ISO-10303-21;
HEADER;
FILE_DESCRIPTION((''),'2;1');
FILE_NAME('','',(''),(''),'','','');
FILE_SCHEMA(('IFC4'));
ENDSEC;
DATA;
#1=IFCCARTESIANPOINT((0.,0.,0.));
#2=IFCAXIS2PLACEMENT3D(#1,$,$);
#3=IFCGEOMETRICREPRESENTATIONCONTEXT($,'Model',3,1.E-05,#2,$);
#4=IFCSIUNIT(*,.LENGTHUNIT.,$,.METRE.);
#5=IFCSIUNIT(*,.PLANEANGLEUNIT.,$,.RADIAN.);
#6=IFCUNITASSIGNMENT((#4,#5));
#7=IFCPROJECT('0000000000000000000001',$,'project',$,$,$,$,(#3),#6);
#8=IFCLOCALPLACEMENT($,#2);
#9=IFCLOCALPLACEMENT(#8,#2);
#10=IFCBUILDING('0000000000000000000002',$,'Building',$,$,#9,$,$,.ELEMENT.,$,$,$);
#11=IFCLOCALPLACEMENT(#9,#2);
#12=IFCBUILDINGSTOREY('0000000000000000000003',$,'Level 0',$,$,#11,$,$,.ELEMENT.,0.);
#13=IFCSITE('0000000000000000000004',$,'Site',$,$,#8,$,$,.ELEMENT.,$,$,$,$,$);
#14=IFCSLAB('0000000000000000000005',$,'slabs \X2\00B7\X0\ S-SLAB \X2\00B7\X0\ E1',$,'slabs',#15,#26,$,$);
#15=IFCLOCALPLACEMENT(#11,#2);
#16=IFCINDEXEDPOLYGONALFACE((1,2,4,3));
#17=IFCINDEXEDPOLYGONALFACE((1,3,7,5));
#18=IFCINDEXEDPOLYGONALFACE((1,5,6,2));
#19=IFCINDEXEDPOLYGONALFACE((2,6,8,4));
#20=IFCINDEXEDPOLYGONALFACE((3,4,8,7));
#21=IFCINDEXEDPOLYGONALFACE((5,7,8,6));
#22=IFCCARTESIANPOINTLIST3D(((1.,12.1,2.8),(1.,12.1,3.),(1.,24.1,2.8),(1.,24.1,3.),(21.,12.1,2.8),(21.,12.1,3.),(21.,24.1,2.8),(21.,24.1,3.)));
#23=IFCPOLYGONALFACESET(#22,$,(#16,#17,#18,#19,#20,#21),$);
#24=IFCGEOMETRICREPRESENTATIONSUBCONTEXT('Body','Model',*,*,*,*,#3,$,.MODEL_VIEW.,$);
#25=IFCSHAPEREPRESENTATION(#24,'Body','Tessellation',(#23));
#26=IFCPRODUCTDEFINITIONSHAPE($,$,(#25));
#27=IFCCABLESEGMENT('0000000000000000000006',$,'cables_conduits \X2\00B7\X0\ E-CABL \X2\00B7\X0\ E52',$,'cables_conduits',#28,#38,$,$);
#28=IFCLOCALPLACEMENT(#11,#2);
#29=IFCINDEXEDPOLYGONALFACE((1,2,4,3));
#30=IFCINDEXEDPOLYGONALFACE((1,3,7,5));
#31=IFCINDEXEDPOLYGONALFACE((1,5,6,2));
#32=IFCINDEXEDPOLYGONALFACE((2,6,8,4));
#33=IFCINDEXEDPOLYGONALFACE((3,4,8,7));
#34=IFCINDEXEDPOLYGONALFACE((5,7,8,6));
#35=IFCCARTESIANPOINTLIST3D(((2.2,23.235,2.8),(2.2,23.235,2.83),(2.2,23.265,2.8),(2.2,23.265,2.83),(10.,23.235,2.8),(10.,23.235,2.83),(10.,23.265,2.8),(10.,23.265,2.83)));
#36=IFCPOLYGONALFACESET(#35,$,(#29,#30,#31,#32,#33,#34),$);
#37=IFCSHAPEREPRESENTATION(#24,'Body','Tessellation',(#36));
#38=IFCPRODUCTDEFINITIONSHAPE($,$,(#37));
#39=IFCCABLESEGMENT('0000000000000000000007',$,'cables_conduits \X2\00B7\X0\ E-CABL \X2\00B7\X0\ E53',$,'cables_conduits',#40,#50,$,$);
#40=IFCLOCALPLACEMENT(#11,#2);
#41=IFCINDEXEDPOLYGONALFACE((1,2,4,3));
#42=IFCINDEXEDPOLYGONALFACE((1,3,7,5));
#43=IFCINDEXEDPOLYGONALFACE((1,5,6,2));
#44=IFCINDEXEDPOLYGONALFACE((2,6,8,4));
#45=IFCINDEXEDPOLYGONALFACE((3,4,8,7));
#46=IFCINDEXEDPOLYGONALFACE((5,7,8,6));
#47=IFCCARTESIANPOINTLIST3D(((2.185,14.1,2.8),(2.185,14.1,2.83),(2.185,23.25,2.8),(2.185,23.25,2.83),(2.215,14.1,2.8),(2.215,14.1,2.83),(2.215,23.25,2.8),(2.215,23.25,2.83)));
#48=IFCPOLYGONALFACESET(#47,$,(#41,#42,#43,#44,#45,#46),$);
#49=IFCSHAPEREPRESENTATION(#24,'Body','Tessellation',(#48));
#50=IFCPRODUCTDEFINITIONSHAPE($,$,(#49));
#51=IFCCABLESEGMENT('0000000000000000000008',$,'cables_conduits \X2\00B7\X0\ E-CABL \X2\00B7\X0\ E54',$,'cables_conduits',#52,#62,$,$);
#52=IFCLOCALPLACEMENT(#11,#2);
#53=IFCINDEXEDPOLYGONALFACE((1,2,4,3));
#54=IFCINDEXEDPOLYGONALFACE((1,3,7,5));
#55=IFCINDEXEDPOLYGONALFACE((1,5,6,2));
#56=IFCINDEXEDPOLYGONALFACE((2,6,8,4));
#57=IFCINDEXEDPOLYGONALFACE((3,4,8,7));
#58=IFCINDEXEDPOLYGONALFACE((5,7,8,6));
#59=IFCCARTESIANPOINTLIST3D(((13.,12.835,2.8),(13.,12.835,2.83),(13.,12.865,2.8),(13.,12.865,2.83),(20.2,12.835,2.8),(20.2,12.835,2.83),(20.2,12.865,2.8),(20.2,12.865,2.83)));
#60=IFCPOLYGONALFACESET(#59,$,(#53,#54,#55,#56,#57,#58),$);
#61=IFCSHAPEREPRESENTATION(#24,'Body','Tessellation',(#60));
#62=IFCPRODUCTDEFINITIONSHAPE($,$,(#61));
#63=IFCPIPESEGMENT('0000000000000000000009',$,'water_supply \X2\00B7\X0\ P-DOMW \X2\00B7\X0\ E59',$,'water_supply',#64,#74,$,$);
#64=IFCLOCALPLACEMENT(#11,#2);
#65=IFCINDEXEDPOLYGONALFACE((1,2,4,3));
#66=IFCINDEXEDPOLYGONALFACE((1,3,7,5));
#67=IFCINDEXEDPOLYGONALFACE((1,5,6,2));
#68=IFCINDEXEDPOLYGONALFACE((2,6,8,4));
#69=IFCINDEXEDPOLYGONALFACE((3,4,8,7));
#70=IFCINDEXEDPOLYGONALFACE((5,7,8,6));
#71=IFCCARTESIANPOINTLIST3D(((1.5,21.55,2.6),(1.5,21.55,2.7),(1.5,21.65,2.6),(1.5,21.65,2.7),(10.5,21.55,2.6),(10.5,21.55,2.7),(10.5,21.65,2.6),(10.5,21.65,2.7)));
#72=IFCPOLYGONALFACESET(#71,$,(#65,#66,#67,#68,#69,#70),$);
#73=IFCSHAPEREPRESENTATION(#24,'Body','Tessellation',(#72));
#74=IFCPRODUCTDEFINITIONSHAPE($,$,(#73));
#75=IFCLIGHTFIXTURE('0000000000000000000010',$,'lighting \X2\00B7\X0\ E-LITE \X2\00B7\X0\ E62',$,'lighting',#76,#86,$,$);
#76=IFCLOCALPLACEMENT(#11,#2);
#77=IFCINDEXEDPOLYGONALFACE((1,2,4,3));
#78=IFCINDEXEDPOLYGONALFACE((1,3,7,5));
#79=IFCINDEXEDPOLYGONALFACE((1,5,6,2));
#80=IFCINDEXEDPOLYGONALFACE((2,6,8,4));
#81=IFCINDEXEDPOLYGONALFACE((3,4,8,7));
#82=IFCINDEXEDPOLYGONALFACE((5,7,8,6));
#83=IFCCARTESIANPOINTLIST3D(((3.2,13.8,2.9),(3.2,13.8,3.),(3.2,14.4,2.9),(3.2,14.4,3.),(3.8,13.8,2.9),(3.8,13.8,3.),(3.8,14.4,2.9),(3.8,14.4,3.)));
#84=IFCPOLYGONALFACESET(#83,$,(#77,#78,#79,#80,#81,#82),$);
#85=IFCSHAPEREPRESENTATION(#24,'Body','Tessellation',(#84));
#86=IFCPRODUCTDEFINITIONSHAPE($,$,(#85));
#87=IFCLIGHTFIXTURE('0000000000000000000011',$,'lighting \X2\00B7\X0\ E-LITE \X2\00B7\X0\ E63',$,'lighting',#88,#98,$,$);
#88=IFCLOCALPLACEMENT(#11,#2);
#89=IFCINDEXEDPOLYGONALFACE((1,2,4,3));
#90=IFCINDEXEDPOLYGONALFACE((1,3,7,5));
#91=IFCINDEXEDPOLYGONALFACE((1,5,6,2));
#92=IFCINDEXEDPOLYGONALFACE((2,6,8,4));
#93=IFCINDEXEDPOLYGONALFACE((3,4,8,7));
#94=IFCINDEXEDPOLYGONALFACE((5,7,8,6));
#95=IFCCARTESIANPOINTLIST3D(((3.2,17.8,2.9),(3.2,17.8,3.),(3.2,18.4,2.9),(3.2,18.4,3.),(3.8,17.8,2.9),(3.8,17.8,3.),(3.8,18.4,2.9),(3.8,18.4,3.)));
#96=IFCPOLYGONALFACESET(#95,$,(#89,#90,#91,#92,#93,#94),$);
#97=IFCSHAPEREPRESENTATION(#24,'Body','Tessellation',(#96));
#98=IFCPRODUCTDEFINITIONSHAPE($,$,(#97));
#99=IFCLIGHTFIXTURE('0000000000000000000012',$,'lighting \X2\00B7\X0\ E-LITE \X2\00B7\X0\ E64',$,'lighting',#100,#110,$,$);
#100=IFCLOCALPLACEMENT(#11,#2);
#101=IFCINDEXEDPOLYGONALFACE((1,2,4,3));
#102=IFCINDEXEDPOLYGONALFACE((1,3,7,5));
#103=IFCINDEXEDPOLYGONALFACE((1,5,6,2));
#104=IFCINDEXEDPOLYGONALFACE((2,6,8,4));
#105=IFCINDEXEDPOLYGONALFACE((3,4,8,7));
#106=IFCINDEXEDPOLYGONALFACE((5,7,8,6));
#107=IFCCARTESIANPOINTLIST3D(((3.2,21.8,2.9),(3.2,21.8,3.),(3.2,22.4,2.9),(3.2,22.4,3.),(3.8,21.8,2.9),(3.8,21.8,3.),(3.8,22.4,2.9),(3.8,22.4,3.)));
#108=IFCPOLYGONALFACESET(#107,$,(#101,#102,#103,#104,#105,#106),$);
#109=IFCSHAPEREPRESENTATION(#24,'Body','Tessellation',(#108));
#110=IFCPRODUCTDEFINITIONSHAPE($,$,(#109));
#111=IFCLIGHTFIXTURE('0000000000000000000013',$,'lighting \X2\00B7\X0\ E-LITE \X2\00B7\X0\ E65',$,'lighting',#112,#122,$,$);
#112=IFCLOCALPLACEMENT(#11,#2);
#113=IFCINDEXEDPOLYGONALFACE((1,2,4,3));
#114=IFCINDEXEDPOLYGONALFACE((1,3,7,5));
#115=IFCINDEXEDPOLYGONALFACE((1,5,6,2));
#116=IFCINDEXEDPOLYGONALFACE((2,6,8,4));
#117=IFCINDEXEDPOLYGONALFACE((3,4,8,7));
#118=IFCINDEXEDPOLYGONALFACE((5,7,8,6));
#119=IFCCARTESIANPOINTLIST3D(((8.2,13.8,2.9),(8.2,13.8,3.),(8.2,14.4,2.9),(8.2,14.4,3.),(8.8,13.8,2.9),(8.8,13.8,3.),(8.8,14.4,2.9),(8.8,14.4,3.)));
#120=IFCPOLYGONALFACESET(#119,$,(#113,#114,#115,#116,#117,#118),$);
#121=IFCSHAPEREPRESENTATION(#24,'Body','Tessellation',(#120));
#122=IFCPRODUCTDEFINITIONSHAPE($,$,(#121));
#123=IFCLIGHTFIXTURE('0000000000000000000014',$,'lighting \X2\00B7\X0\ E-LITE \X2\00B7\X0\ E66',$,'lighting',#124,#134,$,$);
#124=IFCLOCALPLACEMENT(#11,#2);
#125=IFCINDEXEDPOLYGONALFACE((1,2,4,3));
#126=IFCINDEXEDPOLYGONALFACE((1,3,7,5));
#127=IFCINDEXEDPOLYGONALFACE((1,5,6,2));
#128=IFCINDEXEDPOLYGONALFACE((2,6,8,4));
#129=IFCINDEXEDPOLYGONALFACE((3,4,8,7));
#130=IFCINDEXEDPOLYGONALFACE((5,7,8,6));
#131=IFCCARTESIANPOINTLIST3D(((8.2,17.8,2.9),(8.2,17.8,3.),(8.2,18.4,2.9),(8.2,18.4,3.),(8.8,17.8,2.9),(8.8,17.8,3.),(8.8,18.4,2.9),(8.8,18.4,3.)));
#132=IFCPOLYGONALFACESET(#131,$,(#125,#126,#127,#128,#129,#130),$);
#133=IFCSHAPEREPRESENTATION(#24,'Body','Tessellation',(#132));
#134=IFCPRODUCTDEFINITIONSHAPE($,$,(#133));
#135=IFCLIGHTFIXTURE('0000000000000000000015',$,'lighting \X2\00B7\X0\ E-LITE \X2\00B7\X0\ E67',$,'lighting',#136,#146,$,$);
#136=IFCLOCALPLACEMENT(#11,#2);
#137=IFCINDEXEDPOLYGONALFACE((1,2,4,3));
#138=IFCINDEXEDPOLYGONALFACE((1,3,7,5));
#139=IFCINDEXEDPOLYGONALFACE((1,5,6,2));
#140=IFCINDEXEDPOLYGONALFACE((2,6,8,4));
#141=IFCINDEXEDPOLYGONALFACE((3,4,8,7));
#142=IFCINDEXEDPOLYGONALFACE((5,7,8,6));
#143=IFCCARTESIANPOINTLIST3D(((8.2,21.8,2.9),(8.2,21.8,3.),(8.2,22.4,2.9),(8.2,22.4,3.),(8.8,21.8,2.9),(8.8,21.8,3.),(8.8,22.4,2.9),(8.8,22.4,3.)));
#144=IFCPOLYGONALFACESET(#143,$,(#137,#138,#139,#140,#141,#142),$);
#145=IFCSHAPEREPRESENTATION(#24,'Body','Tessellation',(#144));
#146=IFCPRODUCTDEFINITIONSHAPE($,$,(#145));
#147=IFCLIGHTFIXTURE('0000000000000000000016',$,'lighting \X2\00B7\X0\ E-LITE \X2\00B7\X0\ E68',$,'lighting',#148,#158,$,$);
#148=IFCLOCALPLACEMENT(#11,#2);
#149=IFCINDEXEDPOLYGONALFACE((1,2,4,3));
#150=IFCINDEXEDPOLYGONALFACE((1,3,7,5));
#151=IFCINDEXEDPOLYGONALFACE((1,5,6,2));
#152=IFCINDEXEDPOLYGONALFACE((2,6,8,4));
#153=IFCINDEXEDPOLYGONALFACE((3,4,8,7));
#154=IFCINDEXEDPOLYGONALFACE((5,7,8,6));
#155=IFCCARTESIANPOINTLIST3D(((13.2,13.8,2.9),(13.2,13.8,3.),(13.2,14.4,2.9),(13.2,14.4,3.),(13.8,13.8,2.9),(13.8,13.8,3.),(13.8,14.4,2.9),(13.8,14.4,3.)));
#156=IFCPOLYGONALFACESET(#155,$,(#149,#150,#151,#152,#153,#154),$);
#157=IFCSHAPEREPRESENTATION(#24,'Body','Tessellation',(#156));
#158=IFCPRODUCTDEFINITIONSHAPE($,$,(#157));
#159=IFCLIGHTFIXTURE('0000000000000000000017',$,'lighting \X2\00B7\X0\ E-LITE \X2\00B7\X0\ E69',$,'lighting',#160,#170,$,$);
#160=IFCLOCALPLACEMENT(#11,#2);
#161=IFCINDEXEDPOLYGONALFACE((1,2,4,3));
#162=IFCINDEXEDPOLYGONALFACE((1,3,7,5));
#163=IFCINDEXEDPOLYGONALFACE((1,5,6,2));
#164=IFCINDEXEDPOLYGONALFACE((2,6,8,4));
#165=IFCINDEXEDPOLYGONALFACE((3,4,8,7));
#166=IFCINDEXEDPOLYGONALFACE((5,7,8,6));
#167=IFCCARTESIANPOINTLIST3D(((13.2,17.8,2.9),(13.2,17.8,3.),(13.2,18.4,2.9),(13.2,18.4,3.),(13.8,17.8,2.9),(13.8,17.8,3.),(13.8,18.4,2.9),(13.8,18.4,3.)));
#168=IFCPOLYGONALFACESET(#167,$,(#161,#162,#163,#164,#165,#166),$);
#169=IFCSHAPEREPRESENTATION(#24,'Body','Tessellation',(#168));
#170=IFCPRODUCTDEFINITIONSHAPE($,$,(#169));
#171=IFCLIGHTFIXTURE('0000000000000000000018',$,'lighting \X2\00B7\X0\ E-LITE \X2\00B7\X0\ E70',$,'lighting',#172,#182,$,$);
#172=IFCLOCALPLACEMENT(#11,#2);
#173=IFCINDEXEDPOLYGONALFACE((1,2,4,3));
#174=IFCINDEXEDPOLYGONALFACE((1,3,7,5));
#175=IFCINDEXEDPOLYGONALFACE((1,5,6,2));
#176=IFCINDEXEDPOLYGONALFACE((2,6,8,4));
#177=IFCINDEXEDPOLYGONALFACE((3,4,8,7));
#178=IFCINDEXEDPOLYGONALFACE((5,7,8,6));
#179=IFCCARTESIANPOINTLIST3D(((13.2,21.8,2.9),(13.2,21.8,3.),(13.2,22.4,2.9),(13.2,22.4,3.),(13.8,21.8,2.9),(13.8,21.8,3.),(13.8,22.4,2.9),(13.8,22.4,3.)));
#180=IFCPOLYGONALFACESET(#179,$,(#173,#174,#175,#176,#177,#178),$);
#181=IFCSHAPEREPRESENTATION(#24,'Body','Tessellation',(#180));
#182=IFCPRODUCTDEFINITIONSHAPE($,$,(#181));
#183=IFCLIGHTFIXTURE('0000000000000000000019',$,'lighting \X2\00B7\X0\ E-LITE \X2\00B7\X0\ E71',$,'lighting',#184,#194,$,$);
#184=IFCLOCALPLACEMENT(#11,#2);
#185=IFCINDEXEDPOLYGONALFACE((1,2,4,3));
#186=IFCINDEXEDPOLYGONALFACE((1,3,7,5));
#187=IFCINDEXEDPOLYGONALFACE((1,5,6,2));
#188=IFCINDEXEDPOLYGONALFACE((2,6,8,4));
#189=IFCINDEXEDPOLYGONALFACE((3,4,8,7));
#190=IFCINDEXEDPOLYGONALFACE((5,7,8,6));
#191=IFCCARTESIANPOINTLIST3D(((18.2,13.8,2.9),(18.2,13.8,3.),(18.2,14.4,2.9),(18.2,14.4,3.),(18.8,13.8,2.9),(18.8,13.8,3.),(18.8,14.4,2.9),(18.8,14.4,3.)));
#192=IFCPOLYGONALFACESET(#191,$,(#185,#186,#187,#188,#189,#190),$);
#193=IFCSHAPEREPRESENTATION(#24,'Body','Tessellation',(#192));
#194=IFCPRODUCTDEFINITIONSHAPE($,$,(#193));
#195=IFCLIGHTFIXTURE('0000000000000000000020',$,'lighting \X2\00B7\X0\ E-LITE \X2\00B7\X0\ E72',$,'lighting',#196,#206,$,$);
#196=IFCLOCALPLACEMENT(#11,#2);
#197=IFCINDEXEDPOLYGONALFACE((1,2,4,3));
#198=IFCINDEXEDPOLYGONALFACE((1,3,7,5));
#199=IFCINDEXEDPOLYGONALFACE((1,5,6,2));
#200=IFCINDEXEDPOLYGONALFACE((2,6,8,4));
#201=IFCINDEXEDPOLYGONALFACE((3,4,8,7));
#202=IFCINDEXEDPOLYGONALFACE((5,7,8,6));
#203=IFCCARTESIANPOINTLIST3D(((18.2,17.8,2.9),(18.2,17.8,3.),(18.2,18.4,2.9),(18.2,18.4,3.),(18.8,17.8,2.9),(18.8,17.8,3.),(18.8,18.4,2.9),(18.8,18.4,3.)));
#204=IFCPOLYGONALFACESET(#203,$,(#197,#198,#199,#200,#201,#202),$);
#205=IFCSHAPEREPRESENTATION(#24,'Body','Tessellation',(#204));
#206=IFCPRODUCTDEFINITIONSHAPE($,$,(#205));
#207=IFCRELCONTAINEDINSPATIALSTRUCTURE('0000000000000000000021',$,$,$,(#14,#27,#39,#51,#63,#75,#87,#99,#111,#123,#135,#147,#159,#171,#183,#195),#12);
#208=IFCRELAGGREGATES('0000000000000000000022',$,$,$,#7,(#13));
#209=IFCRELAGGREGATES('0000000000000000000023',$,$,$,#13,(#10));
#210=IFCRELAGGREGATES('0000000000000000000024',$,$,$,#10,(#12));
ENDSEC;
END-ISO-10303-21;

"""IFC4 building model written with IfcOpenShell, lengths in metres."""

from ifc_helpers import new_model, si_unit, frame, origin, place, context, subcontext, project, spatial, polyline, outline, extrude, element, save


model = new_model("IFC4")

# Units and contexts
model_context = context("Model", 3, precision=1e-05, world=origin())
body_context = subcontext(model_context, "Body", "Model", "MODEL_VIEW")
ifc_project = project(units=[si_unit("LENGTHUNIT", "METRE"), si_unit("PLANEANGLEUNIT", "RADIAN")], contexts=[model_context])

# Site, building, storey
site_placement = place(None, origin())
site = spatial("IfcSite", under=ifc_project, at=site_placement, Name="Site", CompositionType="ELEMENT")
building_placement = place(site_placement, origin())
building = spatial("IfcBuilding", under=site, at=building_placement, Name="Building", CompositionType="ELEMENT")
storey_placement = place(building_placement, origin())
storey = spatial("IfcBuildingStorey", under=building, at=storey_placement, Name="Level 0", CompositionType="ELEMENT", Elevation=0.0)

# Slab
slab_placement = place(storey_placement, frame((0.0, 0.0, 2.8)))
element("IfcSlab", 1, at=slab_placement, inside=storey, Name="slabs · S-SLAB · E1", ObjectType="slabs", context=body_context, shape_type="SweptSolid", body=[
    extrude(outline(polyline([(1.0, 12.1), (21.0, 12.1), (21.0, 24.1), (1.0, 24.1), (1.0, 12.1)])), origin(), (0.0, 0.0, 1.0), 0.2),
])

# Cable segments
cable_segment_1_placement = place(storey_placement, frame((0.0, 0.0, 2.8)))
element("IfcCableSegment", 2, at=cable_segment_1_placement, inside=storey, Name="cables_conduits · E-CABL · E52", ObjectType="cables_conduits", context=body_context, shape_type="SweptSolid", body=[
    extrude(outline(polyline([(2.2, 23.235), (10.0, 23.235), (10.0, 23.265), (2.2, 23.265), (2.2, 23.235)])), origin(), (0.0, 0.0, 1.0), 0.03),
])
cable_segment_2_placement = place(storey_placement, frame((0.0, 0.0, 2.8)))
element("IfcCableSegment", 3, at=cable_segment_2_placement, inside=storey, Name="cables_conduits · E-CABL · E53", ObjectType="cables_conduits", context=body_context, shape_type="SweptSolid", body=[
    extrude(outline(polyline([(2.185, 23.25), (2.185, 14.1), (2.215, 14.1), (2.215, 23.25), (2.185, 23.25)])), origin(), (0.0, 0.0, 1.0), 0.03),
])
cable_segment_3_placement = place(storey_placement, frame((0.0, 0.0, 2.8)))
element("IfcCableSegment", 4, at=cable_segment_3_placement, inside=storey, Name="cables_conduits · E-CABL · E54", ObjectType="cables_conduits", context=body_context, shape_type="SweptSolid", body=[
    extrude(outline(polyline([(20.2, 12.865), (13.0, 12.865), (13.0, 12.835), (20.2, 12.835), (20.2, 12.865)])), origin(), (0.0, 0.0, 1.0), 0.03),
])

# Pipe segment
pipe_segment_placement = place(storey_placement, frame((0.0, 0.0, 2.6)))
element("IfcPipeSegment", 5, at=pipe_segment_placement, inside=storey, Name="water_supply · P-DOMW · E59", ObjectType="water_supply", context=body_context, shape_type="SweptSolid", body=[
    extrude(outline(polyline([(1.5, 21.55), (10.5, 21.55), (10.5, 21.65), (1.5, 21.65), (1.5, 21.55)])), origin(), (0.0, 0.0, 1.0), 0.1),
])

# Light fixtures
light_fixture_1_placement = place(storey_placement, frame((0.0, 0.0, 2.9)))
element("IfcLightFixture", 6, at=light_fixture_1_placement, inside=storey, Name="lighting · E-LITE · E62", ObjectType="lighting", context=body_context, shape_type="SweptSolid", body=[
    extrude(outline(polyline([(3.2, 13.8), (3.8, 13.8), (3.8, 14.4), (3.2, 14.4), (3.2, 13.8)])), origin(), (0.0, 0.0, 1.0), 0.1),
])
light_fixture_2_placement = place(storey_placement, frame((0.0, 0.0, 2.9)))
element("IfcLightFixture", 7, at=light_fixture_2_placement, inside=storey, Name="lighting · E-LITE · E63", ObjectType="lighting", context=body_context, shape_type="SweptSolid", body=[
    extrude(outline(polyline([(3.2, 17.8), (3.8, 17.8), (3.8, 18.4), (3.2, 18.4), (3.2, 17.8)])), origin(), (0.0, 0.0, 1.0), 0.1),
])
light_fixture_3_placement = place(storey_placement, frame((0.0, 0.0, 2.9)))
element("IfcLightFixture", 8, at=light_fixture_3_placement, inside=storey, Name="lighting · E-LITE · E64", ObjectType="lighting", context=body_context, shape_type="SweptSolid", body=[
    extrude(outline(polyline([(3.2, 21.8), (3.8, 21.8), (3.8, 22.4), (3.2, 22.4), (3.2, 21.8)])), origin(), (0.0, 0.0, 1.0), 0.1),
])
light_fixture_4_placement = place(storey_placement, frame((0.0, 0.0, 2.9)))
element("IfcLightFixture", 9, at=light_fixture_4_placement, inside=storey, Name="lighting · E-LITE · E65", ObjectType="lighting", context=body_context, shape_type="SweptSolid", body=[
    extrude(outline(polyline([(8.2, 13.8), (8.8, 13.8), (8.8, 14.4), (8.2, 14.4), (8.2, 13.8)])), origin(), (0.0, 0.0, 1.0), 0.1),
])
light_fixture_5_placement = place(storey_placement, frame((0.0, 0.0, 2.9)))
element("IfcLightFixture", 10, at=light_fixture_5_placement, inside=storey, Name="lighting · E-LITE · E66", ObjectType="lighting", context=body_context, shape_type="SweptSolid", body=[
    extrude(outline(polyline([(8.2, 17.8), (8.8, 17.8), (8.8, 18.4), (8.2, 18.4), (8.2, 17.8)])), origin(), (0.0, 0.0, 1.0), 0.1),
])
light_fixture_6_placement = place(storey_placement, frame((0.0, 0.0, 2.9)))
element("IfcLightFixture", 11, at=light_fixture_6_placement, inside=storey, Name="lighting · E-LITE · E67", ObjectType="lighting", context=body_context, shape_type="SweptSolid", body=[
    extrude(outline(polyline([(8.2, 21.8), (8.8, 21.8), (8.8, 22.4), (8.2, 22.4), (8.2, 21.8)])), origin(), (0.0, 0.0, 1.0), 0.1),
])
light_fixture_7_placement = place(storey_placement, frame((0.0, 0.0, 2.9)))
element("IfcLightFixture", 12, at=light_fixture_7_placement, inside=storey, Name="lighting · E-LITE · E68", ObjectType="lighting", context=body_context, shape_type="SweptSolid", body=[
    extrude(outline(polyline([(13.2, 13.8), (13.8, 13.8), (13.8, 14.4), (13.2, 14.4), (13.2, 13.8)])), origin(), (0.0, 0.0, 1.0), 0.1),
])
light_fixture_8_placement = place(storey_placement, frame((0.0, 0.0, 2.9)))
element("IfcLightFixture", 13, at=light_fixture_8_placement, inside=storey, Name="lighting · E-LITE · E69", ObjectType="lighting", context=body_context, shape_type="SweptSolid", body=[
    extrude(outline(polyline([(13.2, 17.8), (13.8, 17.8), (13.8, 18.4), (13.2, 18.4), (13.2, 17.8)])), origin(), (0.0, 0.0, 1.0), 0.1),
])
light_fixture_9_placement = place(storey_placement, frame((0.0, 0.0, 2.9)))
element("IfcLightFixture", 14, at=light_fixture_9_placement, inside=storey, Name="lighting · E-LITE · E70", ObjectType="lighting", context=body_context, shape_type="SweptSolid", body=[
    extrude(outline(polyline([(13.2, 21.8), (13.8, 21.8), (13.8, 22.4), (13.2, 22.4), (13.2, 21.8)])), origin(), (0.0, 0.0, 1.0), 0.1),
])
light_fixture_10_placement = place(storey_placement, frame((0.0, 0.0, 2.9)))
element("IfcLightFixture", 15, at=light_fixture_10_placement, inside=storey, Name="lighting · E-LITE · E71", ObjectType="lighting", context=body_context, shape_type="SweptSolid", body=[
    extrude(outline(polyline([(18.2, 13.8), (18.8, 13.8), (18.8, 14.4), (18.2, 14.4), (18.2, 13.8)])), origin(), (0.0, 0.0, 1.0), 0.1),
])
light_fixture_11_placement = place(storey_placement, frame((0.0, 0.0, 2.9)))
element("IfcLightFixture", 16, at=light_fixture_11_placement, inside=storey, Name="lighting · E-LITE · E72", ObjectType="lighting", context=body_context, shape_type="SweptSolid", body=[
    extrude(outline(polyline([(18.2, 17.8), (18.8, 17.8), (18.8, 18.4), (18.2, 18.4), (18.2, 17.8)])), origin(), (0.0, 0.0, 1.0), 0.1),
])

save(model, "model.ifc")
